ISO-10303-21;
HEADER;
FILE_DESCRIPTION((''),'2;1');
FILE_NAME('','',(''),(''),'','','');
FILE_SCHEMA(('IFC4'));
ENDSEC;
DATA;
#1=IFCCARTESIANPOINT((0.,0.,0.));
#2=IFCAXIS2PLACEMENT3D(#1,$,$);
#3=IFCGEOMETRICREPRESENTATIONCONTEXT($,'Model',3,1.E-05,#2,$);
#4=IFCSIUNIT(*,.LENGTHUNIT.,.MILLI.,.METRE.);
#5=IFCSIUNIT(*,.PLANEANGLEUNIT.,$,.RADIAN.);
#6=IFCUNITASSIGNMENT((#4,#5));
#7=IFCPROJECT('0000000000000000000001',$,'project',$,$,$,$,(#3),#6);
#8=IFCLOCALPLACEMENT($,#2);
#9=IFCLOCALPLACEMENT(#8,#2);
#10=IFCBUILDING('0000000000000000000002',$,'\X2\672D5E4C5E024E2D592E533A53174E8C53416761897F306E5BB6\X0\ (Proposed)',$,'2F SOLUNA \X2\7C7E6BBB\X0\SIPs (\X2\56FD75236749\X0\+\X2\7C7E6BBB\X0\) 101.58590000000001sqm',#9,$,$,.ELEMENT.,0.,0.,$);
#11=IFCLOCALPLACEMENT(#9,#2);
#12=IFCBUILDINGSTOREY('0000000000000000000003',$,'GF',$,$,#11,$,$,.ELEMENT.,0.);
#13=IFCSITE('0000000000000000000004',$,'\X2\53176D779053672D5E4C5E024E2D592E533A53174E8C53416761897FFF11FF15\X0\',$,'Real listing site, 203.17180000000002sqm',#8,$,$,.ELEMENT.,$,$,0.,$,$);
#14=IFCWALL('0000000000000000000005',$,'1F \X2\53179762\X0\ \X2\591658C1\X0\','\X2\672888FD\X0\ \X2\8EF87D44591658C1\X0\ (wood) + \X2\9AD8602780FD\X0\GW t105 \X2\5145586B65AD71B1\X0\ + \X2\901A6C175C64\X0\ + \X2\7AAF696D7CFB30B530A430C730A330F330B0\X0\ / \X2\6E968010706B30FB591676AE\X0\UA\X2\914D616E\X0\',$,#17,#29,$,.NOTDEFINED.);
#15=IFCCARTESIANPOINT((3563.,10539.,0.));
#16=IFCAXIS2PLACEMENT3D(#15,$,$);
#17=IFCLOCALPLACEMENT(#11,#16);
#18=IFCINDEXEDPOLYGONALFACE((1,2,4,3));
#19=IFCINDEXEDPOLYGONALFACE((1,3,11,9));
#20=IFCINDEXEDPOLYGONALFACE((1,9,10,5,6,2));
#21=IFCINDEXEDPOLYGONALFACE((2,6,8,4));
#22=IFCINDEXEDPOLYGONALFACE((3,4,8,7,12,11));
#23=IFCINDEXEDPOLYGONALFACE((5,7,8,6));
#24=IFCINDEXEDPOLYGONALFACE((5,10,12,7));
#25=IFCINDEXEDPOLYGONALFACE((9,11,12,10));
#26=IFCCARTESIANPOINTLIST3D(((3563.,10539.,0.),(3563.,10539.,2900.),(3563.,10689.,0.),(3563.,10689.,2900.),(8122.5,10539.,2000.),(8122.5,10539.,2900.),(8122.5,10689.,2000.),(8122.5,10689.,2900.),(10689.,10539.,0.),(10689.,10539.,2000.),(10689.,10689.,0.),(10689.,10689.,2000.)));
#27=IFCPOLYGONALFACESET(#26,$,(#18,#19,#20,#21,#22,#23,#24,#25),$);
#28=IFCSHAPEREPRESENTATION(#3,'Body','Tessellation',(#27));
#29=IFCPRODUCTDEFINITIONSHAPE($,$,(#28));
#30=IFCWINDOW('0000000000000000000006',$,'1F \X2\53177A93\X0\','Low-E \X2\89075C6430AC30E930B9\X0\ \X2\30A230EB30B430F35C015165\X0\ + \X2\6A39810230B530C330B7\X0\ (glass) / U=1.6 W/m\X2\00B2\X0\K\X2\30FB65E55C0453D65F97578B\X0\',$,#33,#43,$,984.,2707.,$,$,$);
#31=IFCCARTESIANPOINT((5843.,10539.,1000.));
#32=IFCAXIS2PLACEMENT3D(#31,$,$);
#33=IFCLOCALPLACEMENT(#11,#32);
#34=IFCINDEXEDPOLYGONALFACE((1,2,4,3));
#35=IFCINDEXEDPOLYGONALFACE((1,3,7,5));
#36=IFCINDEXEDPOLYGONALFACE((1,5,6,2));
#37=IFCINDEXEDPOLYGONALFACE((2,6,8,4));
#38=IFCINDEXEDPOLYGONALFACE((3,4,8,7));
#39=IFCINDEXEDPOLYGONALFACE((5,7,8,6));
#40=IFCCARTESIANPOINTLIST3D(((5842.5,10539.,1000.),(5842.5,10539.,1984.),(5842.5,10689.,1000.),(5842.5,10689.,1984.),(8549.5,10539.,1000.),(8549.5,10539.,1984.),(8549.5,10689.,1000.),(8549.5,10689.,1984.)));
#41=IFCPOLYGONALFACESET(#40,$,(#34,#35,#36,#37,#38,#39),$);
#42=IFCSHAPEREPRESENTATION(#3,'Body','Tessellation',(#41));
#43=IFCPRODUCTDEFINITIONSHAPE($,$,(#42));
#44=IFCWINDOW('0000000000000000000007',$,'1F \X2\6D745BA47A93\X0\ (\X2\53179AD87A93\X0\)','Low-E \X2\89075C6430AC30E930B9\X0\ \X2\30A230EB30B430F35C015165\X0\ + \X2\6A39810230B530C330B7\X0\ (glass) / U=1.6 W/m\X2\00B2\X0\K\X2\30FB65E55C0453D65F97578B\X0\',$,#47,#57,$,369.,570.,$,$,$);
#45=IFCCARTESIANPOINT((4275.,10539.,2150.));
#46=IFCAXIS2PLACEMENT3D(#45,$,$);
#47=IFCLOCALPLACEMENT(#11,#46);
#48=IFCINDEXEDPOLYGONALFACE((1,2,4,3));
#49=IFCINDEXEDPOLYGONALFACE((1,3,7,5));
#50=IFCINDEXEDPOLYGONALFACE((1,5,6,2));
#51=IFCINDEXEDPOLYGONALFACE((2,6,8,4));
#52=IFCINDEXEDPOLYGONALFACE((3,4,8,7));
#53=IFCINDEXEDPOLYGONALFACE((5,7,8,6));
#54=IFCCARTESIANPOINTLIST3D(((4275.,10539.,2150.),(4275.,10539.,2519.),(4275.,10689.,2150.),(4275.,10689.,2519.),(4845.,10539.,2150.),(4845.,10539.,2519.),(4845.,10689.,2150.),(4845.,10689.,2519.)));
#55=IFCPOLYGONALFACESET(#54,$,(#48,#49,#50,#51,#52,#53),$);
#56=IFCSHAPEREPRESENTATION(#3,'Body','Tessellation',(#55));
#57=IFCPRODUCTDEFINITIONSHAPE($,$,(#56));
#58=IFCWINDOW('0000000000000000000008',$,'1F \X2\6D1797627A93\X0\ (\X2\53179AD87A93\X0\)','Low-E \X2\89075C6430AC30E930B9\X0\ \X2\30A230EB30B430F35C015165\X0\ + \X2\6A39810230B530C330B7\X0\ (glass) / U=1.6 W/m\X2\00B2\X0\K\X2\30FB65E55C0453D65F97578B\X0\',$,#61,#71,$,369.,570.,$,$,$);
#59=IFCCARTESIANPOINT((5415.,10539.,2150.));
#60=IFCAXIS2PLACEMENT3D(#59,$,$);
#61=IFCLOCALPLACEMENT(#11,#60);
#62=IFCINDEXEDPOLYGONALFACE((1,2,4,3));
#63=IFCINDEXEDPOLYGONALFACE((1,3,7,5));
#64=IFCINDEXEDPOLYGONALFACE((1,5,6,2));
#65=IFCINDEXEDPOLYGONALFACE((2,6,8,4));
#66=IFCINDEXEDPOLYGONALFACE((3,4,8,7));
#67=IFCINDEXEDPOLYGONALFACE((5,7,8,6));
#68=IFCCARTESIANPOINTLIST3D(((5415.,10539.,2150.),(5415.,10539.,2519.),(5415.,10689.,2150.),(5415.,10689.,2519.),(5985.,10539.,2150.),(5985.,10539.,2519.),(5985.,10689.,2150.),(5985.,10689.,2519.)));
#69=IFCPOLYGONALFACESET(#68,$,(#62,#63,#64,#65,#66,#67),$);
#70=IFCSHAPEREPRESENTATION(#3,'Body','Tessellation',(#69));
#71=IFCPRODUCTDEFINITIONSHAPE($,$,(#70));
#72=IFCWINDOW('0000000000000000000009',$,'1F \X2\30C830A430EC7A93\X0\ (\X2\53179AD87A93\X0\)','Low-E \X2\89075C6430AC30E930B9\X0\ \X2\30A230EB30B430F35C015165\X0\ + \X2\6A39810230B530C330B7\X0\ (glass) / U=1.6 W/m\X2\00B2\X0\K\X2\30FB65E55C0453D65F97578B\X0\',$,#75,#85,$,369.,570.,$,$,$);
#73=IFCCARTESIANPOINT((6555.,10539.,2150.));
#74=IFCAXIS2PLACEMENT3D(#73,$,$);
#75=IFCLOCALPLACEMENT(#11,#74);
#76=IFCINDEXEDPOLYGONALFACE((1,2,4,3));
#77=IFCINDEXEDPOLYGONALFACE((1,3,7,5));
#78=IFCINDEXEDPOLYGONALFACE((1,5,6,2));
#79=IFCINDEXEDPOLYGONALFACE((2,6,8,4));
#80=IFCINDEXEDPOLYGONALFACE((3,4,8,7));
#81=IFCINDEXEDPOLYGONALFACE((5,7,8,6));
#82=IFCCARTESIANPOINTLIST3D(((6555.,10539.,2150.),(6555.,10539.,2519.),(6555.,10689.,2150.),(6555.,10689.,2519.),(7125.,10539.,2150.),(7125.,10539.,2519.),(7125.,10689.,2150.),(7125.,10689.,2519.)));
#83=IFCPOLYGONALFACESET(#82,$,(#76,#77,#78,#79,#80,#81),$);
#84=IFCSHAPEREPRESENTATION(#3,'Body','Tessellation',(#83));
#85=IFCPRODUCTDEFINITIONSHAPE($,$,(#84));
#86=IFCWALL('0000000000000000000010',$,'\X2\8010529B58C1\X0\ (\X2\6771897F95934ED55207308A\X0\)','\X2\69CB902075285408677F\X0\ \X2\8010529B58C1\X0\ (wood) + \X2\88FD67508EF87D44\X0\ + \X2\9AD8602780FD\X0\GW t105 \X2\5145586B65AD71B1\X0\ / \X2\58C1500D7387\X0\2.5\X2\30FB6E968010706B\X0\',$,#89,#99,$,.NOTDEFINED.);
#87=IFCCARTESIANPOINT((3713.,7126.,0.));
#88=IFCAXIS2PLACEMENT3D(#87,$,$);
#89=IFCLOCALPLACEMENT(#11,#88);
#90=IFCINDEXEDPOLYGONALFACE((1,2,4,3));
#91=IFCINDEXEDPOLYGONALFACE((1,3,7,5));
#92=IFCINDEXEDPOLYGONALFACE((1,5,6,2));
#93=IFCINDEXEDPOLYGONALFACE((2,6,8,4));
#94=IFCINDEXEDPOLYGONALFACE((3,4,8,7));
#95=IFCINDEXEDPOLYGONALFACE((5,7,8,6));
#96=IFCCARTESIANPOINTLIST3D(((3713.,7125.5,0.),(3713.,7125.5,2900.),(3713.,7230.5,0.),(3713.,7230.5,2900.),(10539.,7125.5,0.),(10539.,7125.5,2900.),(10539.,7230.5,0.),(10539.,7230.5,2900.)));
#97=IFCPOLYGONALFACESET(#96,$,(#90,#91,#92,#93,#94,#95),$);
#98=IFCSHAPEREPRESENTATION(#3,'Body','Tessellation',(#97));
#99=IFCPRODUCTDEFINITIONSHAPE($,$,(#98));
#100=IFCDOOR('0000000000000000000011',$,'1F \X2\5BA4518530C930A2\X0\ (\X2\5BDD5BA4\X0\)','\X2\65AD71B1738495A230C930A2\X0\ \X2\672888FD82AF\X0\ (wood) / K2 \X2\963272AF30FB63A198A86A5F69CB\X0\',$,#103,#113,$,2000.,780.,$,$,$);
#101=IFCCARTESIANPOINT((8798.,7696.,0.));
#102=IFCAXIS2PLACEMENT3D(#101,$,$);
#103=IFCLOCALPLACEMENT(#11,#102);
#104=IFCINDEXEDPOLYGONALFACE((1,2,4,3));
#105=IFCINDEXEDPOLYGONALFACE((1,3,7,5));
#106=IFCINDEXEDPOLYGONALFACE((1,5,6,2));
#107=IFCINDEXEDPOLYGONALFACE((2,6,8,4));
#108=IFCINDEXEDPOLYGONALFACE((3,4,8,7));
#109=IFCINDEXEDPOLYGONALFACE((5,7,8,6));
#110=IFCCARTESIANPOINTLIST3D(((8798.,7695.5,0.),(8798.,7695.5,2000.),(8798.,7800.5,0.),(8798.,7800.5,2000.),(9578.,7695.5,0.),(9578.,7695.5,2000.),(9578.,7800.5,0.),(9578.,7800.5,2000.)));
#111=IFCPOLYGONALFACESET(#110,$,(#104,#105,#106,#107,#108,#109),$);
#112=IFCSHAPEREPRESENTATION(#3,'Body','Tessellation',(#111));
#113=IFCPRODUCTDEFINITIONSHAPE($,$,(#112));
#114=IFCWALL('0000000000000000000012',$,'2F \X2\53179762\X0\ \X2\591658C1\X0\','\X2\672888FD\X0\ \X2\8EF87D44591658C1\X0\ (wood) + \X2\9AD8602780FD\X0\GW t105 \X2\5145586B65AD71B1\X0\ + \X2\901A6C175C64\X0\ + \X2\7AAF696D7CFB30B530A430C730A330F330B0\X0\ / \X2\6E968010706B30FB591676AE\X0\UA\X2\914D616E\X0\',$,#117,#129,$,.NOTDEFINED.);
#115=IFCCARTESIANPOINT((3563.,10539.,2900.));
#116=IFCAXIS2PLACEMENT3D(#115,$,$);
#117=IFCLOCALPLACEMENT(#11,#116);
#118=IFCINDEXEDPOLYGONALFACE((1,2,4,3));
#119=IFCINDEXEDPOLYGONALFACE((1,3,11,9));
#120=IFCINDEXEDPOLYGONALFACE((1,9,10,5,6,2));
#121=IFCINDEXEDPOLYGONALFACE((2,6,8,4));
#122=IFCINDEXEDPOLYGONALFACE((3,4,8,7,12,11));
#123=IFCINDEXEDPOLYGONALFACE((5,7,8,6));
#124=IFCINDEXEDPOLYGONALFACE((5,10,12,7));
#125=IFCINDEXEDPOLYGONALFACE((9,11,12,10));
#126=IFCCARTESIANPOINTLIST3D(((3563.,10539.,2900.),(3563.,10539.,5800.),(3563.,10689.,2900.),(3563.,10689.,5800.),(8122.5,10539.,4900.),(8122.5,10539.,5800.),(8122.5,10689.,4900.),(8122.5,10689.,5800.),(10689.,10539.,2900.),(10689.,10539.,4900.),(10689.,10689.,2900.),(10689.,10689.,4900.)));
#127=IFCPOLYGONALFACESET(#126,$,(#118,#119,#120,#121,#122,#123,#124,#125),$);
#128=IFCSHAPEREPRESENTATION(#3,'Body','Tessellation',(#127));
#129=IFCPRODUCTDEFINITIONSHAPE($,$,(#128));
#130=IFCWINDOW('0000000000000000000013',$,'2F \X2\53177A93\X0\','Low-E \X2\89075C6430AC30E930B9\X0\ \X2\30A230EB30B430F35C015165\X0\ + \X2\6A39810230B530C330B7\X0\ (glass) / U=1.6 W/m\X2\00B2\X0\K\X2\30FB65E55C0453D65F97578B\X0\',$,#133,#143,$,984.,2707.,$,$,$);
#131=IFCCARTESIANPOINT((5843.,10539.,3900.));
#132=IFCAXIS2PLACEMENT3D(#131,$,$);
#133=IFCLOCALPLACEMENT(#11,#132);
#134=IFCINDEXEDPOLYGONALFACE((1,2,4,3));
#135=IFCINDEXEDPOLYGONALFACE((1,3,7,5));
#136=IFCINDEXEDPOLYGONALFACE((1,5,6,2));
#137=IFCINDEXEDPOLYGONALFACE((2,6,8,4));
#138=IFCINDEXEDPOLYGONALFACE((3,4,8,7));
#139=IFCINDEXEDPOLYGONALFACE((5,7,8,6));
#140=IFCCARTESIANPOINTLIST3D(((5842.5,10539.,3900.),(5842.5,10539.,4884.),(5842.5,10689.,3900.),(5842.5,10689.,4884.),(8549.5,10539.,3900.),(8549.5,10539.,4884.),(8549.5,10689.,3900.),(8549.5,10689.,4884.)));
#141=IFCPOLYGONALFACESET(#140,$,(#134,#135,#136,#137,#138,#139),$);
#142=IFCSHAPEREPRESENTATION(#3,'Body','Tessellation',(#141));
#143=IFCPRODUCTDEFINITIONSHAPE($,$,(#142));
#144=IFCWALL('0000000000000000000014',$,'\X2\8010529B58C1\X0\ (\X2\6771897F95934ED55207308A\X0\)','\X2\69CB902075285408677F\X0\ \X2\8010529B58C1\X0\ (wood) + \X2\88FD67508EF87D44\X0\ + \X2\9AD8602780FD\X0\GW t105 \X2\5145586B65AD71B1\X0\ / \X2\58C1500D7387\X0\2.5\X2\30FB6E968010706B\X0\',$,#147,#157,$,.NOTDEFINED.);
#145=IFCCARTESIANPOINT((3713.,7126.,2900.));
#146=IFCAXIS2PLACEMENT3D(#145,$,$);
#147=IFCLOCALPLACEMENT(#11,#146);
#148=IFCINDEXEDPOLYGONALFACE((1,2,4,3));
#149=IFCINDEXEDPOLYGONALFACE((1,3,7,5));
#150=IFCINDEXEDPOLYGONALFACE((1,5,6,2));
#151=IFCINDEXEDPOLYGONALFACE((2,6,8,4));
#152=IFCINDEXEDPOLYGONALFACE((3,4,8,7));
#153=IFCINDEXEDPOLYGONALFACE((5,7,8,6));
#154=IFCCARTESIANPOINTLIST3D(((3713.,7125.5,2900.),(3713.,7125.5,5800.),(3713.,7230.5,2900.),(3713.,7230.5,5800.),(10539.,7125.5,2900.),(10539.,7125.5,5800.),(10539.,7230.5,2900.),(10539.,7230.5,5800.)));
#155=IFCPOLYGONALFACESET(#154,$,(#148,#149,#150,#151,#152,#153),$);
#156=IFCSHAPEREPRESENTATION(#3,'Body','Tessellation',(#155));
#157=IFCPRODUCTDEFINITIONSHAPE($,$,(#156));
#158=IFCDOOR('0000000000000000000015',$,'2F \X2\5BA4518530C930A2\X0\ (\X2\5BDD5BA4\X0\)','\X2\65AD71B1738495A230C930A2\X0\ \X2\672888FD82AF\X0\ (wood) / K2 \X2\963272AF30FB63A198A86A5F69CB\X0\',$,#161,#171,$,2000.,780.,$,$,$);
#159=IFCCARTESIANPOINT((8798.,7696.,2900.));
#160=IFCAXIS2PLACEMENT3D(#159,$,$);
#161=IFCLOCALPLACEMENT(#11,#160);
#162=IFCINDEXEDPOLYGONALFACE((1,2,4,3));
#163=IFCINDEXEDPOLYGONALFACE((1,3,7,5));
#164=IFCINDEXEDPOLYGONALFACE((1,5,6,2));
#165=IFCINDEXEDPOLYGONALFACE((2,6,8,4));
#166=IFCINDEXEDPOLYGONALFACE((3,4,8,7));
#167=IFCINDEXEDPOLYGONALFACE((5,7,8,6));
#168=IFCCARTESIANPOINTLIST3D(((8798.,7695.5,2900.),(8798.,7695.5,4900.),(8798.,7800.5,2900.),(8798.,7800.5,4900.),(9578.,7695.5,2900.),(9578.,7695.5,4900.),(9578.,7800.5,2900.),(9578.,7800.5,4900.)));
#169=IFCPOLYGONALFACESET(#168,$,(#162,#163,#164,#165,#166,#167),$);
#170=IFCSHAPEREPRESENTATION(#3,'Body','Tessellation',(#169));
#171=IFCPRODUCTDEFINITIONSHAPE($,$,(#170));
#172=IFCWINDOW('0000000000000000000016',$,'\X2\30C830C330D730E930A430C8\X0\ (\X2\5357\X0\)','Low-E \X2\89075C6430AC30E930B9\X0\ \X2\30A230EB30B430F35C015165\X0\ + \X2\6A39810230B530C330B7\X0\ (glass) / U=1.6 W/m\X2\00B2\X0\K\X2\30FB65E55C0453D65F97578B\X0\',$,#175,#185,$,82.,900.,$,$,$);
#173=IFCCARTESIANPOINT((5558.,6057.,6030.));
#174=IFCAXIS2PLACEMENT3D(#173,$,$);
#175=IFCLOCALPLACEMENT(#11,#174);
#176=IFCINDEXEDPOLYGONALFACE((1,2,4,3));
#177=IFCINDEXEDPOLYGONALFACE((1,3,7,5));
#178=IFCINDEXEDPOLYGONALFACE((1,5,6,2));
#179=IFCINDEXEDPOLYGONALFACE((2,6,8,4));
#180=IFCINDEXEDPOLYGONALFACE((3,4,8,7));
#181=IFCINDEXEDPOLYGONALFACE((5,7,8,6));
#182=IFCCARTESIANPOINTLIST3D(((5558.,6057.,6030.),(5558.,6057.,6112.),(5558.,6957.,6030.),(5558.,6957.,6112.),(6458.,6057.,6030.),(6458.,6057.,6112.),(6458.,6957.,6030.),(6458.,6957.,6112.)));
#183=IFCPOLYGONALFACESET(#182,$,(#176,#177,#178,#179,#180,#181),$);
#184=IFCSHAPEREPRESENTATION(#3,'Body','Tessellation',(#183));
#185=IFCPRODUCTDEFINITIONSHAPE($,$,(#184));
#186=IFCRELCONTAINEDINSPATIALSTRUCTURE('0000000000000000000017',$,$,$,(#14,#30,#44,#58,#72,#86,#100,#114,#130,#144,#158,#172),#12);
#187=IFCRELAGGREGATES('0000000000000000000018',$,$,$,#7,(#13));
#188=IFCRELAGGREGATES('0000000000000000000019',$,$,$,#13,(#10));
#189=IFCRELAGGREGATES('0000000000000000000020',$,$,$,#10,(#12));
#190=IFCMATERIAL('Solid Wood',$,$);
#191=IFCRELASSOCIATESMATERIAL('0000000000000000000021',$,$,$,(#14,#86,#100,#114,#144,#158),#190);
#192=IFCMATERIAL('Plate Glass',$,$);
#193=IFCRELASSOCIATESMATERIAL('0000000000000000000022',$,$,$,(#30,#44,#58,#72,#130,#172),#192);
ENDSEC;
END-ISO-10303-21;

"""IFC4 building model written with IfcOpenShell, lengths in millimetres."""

from ifc_helpers import new_model, si_unit, frame, frame_2d, origin, place, context, project, spatial, rectangle, extrude, material, element, fill, save


model = new_model("IFC4")

# Units and contexts
model_context = context("Model", 3, precision=1e-05, world=origin())
ifc_project = project(units=[si_unit("LENGTHUNIT", "METRE", prefix="MILLI"), si_unit("PLANEANGLEUNIT", "RADIAN")], contexts=[model_context])

# Site, building, storey
site_placement = place(None, origin())
site = spatial("IfcSite", under=ifc_project, at=site_placement, Name="北海道札幌市中央区北二十条西１５", ObjectType="Real listing site, 203.17180000000002sqm", CompositionType="ELEMENT", RefElevation=0.0)
building_placement = place(site_placement, origin())
building = spatial("IfcBuilding", under=site, at=building_placement, Name="札幌市中央区北二十条西の家 (Proposed)", ObjectType="2F SOLUNA 籾殻SIPs (国産杉+籾殻) 101.58590000000001sqm", CompositionType="ELEMENT", ElevationOfRefHeight=0.0, ElevationOfTerrain=0.0)
storey_placement = place(building_placement, origin())
storey = spatial("IfcBuildingStorey", under=building, at=storey_placement, Name="GF", CompositionType="ELEMENT", Elevation=0.0)

# Wall, openings, windows
ifc_material_1 = material(Name="Solid Wood")
wall_1_placement = place(storey_placement, frame((3563.0, 10539.0, 0.0)))
wall_1 = element("IfcWall", 1, at=wall_1_placement, inside=storey, material=ifc_material_1, Name="1F 北面 外壁", Description="木製 軸組外壁 (wood) + 高性能GW t105 充填断熱 + 通気層 + 窯業系サイディング / 準耐火・外皮UA配慮", PredefinedType="NOTDEFINED", context=model_context, shape_type="SweptSolid", body=[
    extrude(rectangle(XDim=7126.0, YDim=150.0, at=frame_2d((3563.0, 75.0))), frame((3563.0, 10539.0, 0.0)), (0.0, 0.0, 1.0), 2900.0),
])
opening_1_placement = place(storey_placement, frame((5843.0, 10539.0, 1000.0)))
opening_1 = element("IfcOpeningElement", 2, at=opening_1_placement, cuts=wall_1, PredefinedType="NOTDEFINED", context=model_context, shape_type="SweptSolid", body=[
    extrude(rectangle(XDim=2707.0, YDim=150.0, at=frame_2d((1353.0, 75.0))), frame((5843.0, 10539.0, 1000.0)), (0.0, 0.0, 1.0), 984.0),
])
opening_2_placement = place(storey_placement, frame((4275.0, 10539.0, 2150.0)))
opening_2 = element("IfcOpeningElement", 3, at=opening_2_placement, cuts=wall_1, PredefinedType="NOTDEFINED", context=model_context, shape_type="SweptSolid", body=[
    extrude(rectangle(XDim=570.0, YDim=150.0, at=frame_2d((285.0, 75.0))), frame((4275.0, 10539.0, 2150.0)), (0.0, 0.0, 1.0), 369.0),
])
opening_3_placement = place(storey_placement, frame((5415.0, 10539.0, 2150.0)))
opening_3 = element("IfcOpeningElement", 4, at=opening_3_placement, cuts=wall_1, PredefinedType="NOTDEFINED", context=model_context, shape_type="SweptSolid", body=[
    extrude(rectangle(XDim=570.0, YDim=150.0, at=frame_2d((285.0, 75.0))), frame((5415.0, 10539.0, 2150.0)), (0.0, 0.0, 1.0), 369.0),
])
opening_4_placement = place(storey_placement, frame((6555.0, 10539.0, 2150.0)))
opening_4 = element("IfcOpeningElement", 5, at=opening_4_placement, cuts=wall_1, PredefinedType="NOTDEFINED", context=model_context, shape_type="SweptSolid", body=[
    extrude(rectangle(XDim=570.0, YDim=150.0, at=frame_2d((285.0, 75.0))), frame((6555.0, 10539.0, 2150.0)), (0.0, 0.0, 1.0), 369.0),
])
ifc_material_2 = material(Name="Plate Glass")
window_1_placement = place(storey_placement, frame((5843.0, 10539.0, 1000.0)))
window_1 = element("IfcWindow", 6, at=window_1_placement, inside=storey, material=ifc_material_2, Name="1F 北窓", Description="Low-E 複層ガラス アルゴン封入 + 樹脂サッシ (glass) / U=1.6 W/m²K・日射取得型", OverallHeight=984.0, OverallWidth=2707.0, context=model_context, shape_type="SweptSolid", body=[
    extrude(rectangle(XDim=2707.0, YDim=150.0, at=frame_2d((1353.0, 75.0))), frame((5843.0, 10539.0, 1000.0)), (0.0, 0.0, 1.0), 984.0),
])
fill(opening_1, window_1)
window_2_placement = place(storey_placement, frame((4275.0, 10539.0, 2150.0)))
window_2 = element("IfcWindow", 7, at=window_2_placement, inside=storey, material=ifc_material_2, Name="1F 浴室窓 (北高窓)", Description="Low-E 複層ガラス アルゴン封入 + 樹脂サッシ (glass) / U=1.6 W/m²K・日射取得型", OverallHeight=369.0, OverallWidth=570.0, context=model_context, shape_type="SweptSolid", body=[
    extrude(rectangle(XDim=570.0, YDim=150.0, at=frame_2d((285.0, 75.0))), frame((4275.0, 10539.0, 2150.0)), (0.0, 0.0, 1.0), 369.0),
])
fill(opening_2, window_2)
window_3_placement = place(storey_placement, frame((5415.0, 10539.0, 2150.0)))
window_3 = element("IfcWindow", 8, at=window_3_placement, inside=storey, material=ifc_material_2, Name="1F 洗面窓 (北高窓)", Description="Low-E 複層ガラス アルゴン封入 + 樹脂サッシ (glass) / U=1.6 W/m²K・日射取得型", OverallHeight=369.0, OverallWidth=570.0, context=model_context, shape_type="SweptSolid", body=[
    extrude(rectangle(XDim=570.0, YDim=150.0, at=frame_2d((285.0, 75.0))), frame((5415.0, 10539.0, 2150.0)), (0.0, 0.0, 1.0), 369.0),
])
fill(opening_3, window_3)
window_4_placement = place(storey_placement, frame((6555.0, 10539.0, 2150.0)))
window_4 = element("IfcWindow", 9, at=window_4_placement, inside=storey, material=ifc_material_2, Name="1F トイレ窓 (北高窓)", Description="Low-E 複層ガラス アルゴン封入 + 樹脂サッシ (glass) / U=1.6 W/m²K・日射取得型", OverallHeight=369.0, OverallWidth=570.0, context=model_context, shape_type="SweptSolid", body=[
    extrude(rectangle(XDim=570.0, YDim=150.0, at=frame_2d((285.0, 75.0))), frame((6555.0, 10539.0, 2150.0)), (0.0, 0.0, 1.0), 369.0),
])
fill(opening_4, window_4)

# Wall
wall_2_placement = place(storey_placement, frame((3713.0, 7126.0, 0.0)))
element("IfcWall", 10, at=wall_2_placement, inside=storey, material=ifc_material_1, Name="耐力壁 (東西間仕切り)", Description="構造用合板 耐力壁 (wood) + 製材軸組 + 高性能GW t105 充填断熱 / 壁倍率2.5・準耐火", PredefinedType="NOTDEFINED", context=model_context, shape_type="SweptSolid", body=[
    extrude(rectangle(XDim=6826.0, YDim=105.0, at=frame_2d((3413.0, 52.0))), frame((3713.0, 7126.0, 0.0)), (0.0, 0.0, 1.0), 2900.0),
])

# Door
door_1_placement = place(storey_placement, frame((8798.0, 7696.0, 0.0)))
element("IfcDoor", 11, at=door_1_placement, inside=storey, material=ifc_material_1, Name="1F 室内ドア (寝室)", Description="断熱玄関ドア 木製芯 (wood) / K2 防犯・採風機構", OverallHeight=2000.0, OverallWidth=780.0, context=model_context, shape_type="SweptSolid", body=[
    extrude(rectangle(XDim=780.0, YDim=105.0, at=frame_2d((390.0, 52.0))), frame((8798.0, 7696.0, 0.0)), (0.0, 0.0, 1.0), 2000.0),
])

# Wall, opening, window
wall_3_placement = place(storey_placement, frame((3563.0, 10539.0, 2900.0)))
wall_3 = element("IfcWall", 12, at=wall_3_placement, inside=storey, material=ifc_material_1, Name="2F 北面 外壁", Description="木製 軸組外壁 (wood) + 高性能GW t105 充填断熱 + 通気層 + 窯業系サイディング / 準耐火・外皮UA配慮", PredefinedType="NOTDEFINED", context=model_context, shape_type="SweptSolid", body=[
    extrude(rectangle(XDim=7126.0, YDim=150.0, at=frame_2d((3563.0, 75.0))), frame((3563.0, 10539.0, 2900.0)), (0.0, 0.0, 1.0), 2900.0),
])
opening_5_placement = place(storey_placement, frame((5843.0, 10539.0, 3900.0)))
opening_5 = element("IfcOpeningElement", 13, at=opening_5_placement, cuts=wall_3, PredefinedType="NOTDEFINED", context=model_context, shape_type="SweptSolid", body=[
    extrude(rectangle(XDim=2707.0, YDim=150.0, at=frame_2d((1353.0, 75.0))), frame((5843.0, 10539.0, 3900.0)), (0.0, 0.0, 1.0), 984.0),
])
window_5_placement = place(storey_placement, frame((5843.0, 10539.0, 3900.0)))
window_5 = element("IfcWindow", 14, at=window_5_placement, inside=storey, material=ifc_material_2, Name="2F 北窓", Description="Low-E 複層ガラス アルゴン封入 + 樹脂サッシ (glass) / U=1.6 W/m²K・日射取得型", OverallHeight=984.0, OverallWidth=2707.0, context=model_context, shape_type="SweptSolid", body=[
    extrude(rectangle(XDim=2707.0, YDim=150.0, at=frame_2d((1353.0, 75.0))), frame((5843.0, 10539.0, 3900.0)), (0.0, 0.0, 1.0), 984.0),
])
fill(opening_5, window_5)

# Wall
wall_4_placement = place(storey_placement, frame((3713.0, 7126.0, 2900.0)))
element("IfcWall", 15, at=wall_4_placement, inside=storey, material=ifc_material_1, Name="耐力壁 (東西間仕切り)", Description="構造用合板 耐力壁 (wood) + 製材軸組 + 高性能GW t105 充填断熱 / 壁倍率2.5・準耐火", PredefinedType="NOTDEFINED", context=model_context, shape_type="SweptSolid", body=[
    extrude(rectangle(XDim=6826.0, YDim=105.0, at=frame_2d((3413.0, 52.0))), frame((3713.0, 7126.0, 2900.0)), (0.0, 0.0, 1.0), 2900.0),
])

# Door
door_2_placement = place(storey_placement, frame((8798.0, 7696.0, 2900.0)))
element("IfcDoor", 16, at=door_2_placement, inside=storey, material=ifc_material_1, Name="2F 室内ドア (寝室)", Description="断熱玄関ドア 木製芯 (wood) / K2 防犯・採風機構", OverallHeight=2000.0, OverallWidth=780.0, context=model_context, shape_type="SweptSolid", body=[
    extrude(rectangle(XDim=780.0, YDim=105.0, at=frame_2d((390.0, 52.0))), frame((8798.0, 7696.0, 2900.0)), (0.0, 0.0, 1.0), 2000.0),
])

# Window
window_6_placement = place(storey_placement, frame((5558.0, 6057.0, 6030.0)))
element("IfcWindow", 17, at=window_6_placement, inside=storey, material=ifc_material_2, Name="トップライト (南)", Description="Low-E 複層ガラス アルゴン封入 + 樹脂サッシ (glass) / U=1.6 W/m²K・日射取得型", OverallHeight=82.0, OverallWidth=900.0, context=model_context, shape_type="SweptSolid", body=[
    extrude(rectangle(XDim=900.0, YDim=900.0, at=frame_2d((450.0, 450.0))), frame((5558.0, 6057.0, 6030.0)), (0.0, 0.0, 1.0), 82.0),
])

save(model, "model.ifc")
